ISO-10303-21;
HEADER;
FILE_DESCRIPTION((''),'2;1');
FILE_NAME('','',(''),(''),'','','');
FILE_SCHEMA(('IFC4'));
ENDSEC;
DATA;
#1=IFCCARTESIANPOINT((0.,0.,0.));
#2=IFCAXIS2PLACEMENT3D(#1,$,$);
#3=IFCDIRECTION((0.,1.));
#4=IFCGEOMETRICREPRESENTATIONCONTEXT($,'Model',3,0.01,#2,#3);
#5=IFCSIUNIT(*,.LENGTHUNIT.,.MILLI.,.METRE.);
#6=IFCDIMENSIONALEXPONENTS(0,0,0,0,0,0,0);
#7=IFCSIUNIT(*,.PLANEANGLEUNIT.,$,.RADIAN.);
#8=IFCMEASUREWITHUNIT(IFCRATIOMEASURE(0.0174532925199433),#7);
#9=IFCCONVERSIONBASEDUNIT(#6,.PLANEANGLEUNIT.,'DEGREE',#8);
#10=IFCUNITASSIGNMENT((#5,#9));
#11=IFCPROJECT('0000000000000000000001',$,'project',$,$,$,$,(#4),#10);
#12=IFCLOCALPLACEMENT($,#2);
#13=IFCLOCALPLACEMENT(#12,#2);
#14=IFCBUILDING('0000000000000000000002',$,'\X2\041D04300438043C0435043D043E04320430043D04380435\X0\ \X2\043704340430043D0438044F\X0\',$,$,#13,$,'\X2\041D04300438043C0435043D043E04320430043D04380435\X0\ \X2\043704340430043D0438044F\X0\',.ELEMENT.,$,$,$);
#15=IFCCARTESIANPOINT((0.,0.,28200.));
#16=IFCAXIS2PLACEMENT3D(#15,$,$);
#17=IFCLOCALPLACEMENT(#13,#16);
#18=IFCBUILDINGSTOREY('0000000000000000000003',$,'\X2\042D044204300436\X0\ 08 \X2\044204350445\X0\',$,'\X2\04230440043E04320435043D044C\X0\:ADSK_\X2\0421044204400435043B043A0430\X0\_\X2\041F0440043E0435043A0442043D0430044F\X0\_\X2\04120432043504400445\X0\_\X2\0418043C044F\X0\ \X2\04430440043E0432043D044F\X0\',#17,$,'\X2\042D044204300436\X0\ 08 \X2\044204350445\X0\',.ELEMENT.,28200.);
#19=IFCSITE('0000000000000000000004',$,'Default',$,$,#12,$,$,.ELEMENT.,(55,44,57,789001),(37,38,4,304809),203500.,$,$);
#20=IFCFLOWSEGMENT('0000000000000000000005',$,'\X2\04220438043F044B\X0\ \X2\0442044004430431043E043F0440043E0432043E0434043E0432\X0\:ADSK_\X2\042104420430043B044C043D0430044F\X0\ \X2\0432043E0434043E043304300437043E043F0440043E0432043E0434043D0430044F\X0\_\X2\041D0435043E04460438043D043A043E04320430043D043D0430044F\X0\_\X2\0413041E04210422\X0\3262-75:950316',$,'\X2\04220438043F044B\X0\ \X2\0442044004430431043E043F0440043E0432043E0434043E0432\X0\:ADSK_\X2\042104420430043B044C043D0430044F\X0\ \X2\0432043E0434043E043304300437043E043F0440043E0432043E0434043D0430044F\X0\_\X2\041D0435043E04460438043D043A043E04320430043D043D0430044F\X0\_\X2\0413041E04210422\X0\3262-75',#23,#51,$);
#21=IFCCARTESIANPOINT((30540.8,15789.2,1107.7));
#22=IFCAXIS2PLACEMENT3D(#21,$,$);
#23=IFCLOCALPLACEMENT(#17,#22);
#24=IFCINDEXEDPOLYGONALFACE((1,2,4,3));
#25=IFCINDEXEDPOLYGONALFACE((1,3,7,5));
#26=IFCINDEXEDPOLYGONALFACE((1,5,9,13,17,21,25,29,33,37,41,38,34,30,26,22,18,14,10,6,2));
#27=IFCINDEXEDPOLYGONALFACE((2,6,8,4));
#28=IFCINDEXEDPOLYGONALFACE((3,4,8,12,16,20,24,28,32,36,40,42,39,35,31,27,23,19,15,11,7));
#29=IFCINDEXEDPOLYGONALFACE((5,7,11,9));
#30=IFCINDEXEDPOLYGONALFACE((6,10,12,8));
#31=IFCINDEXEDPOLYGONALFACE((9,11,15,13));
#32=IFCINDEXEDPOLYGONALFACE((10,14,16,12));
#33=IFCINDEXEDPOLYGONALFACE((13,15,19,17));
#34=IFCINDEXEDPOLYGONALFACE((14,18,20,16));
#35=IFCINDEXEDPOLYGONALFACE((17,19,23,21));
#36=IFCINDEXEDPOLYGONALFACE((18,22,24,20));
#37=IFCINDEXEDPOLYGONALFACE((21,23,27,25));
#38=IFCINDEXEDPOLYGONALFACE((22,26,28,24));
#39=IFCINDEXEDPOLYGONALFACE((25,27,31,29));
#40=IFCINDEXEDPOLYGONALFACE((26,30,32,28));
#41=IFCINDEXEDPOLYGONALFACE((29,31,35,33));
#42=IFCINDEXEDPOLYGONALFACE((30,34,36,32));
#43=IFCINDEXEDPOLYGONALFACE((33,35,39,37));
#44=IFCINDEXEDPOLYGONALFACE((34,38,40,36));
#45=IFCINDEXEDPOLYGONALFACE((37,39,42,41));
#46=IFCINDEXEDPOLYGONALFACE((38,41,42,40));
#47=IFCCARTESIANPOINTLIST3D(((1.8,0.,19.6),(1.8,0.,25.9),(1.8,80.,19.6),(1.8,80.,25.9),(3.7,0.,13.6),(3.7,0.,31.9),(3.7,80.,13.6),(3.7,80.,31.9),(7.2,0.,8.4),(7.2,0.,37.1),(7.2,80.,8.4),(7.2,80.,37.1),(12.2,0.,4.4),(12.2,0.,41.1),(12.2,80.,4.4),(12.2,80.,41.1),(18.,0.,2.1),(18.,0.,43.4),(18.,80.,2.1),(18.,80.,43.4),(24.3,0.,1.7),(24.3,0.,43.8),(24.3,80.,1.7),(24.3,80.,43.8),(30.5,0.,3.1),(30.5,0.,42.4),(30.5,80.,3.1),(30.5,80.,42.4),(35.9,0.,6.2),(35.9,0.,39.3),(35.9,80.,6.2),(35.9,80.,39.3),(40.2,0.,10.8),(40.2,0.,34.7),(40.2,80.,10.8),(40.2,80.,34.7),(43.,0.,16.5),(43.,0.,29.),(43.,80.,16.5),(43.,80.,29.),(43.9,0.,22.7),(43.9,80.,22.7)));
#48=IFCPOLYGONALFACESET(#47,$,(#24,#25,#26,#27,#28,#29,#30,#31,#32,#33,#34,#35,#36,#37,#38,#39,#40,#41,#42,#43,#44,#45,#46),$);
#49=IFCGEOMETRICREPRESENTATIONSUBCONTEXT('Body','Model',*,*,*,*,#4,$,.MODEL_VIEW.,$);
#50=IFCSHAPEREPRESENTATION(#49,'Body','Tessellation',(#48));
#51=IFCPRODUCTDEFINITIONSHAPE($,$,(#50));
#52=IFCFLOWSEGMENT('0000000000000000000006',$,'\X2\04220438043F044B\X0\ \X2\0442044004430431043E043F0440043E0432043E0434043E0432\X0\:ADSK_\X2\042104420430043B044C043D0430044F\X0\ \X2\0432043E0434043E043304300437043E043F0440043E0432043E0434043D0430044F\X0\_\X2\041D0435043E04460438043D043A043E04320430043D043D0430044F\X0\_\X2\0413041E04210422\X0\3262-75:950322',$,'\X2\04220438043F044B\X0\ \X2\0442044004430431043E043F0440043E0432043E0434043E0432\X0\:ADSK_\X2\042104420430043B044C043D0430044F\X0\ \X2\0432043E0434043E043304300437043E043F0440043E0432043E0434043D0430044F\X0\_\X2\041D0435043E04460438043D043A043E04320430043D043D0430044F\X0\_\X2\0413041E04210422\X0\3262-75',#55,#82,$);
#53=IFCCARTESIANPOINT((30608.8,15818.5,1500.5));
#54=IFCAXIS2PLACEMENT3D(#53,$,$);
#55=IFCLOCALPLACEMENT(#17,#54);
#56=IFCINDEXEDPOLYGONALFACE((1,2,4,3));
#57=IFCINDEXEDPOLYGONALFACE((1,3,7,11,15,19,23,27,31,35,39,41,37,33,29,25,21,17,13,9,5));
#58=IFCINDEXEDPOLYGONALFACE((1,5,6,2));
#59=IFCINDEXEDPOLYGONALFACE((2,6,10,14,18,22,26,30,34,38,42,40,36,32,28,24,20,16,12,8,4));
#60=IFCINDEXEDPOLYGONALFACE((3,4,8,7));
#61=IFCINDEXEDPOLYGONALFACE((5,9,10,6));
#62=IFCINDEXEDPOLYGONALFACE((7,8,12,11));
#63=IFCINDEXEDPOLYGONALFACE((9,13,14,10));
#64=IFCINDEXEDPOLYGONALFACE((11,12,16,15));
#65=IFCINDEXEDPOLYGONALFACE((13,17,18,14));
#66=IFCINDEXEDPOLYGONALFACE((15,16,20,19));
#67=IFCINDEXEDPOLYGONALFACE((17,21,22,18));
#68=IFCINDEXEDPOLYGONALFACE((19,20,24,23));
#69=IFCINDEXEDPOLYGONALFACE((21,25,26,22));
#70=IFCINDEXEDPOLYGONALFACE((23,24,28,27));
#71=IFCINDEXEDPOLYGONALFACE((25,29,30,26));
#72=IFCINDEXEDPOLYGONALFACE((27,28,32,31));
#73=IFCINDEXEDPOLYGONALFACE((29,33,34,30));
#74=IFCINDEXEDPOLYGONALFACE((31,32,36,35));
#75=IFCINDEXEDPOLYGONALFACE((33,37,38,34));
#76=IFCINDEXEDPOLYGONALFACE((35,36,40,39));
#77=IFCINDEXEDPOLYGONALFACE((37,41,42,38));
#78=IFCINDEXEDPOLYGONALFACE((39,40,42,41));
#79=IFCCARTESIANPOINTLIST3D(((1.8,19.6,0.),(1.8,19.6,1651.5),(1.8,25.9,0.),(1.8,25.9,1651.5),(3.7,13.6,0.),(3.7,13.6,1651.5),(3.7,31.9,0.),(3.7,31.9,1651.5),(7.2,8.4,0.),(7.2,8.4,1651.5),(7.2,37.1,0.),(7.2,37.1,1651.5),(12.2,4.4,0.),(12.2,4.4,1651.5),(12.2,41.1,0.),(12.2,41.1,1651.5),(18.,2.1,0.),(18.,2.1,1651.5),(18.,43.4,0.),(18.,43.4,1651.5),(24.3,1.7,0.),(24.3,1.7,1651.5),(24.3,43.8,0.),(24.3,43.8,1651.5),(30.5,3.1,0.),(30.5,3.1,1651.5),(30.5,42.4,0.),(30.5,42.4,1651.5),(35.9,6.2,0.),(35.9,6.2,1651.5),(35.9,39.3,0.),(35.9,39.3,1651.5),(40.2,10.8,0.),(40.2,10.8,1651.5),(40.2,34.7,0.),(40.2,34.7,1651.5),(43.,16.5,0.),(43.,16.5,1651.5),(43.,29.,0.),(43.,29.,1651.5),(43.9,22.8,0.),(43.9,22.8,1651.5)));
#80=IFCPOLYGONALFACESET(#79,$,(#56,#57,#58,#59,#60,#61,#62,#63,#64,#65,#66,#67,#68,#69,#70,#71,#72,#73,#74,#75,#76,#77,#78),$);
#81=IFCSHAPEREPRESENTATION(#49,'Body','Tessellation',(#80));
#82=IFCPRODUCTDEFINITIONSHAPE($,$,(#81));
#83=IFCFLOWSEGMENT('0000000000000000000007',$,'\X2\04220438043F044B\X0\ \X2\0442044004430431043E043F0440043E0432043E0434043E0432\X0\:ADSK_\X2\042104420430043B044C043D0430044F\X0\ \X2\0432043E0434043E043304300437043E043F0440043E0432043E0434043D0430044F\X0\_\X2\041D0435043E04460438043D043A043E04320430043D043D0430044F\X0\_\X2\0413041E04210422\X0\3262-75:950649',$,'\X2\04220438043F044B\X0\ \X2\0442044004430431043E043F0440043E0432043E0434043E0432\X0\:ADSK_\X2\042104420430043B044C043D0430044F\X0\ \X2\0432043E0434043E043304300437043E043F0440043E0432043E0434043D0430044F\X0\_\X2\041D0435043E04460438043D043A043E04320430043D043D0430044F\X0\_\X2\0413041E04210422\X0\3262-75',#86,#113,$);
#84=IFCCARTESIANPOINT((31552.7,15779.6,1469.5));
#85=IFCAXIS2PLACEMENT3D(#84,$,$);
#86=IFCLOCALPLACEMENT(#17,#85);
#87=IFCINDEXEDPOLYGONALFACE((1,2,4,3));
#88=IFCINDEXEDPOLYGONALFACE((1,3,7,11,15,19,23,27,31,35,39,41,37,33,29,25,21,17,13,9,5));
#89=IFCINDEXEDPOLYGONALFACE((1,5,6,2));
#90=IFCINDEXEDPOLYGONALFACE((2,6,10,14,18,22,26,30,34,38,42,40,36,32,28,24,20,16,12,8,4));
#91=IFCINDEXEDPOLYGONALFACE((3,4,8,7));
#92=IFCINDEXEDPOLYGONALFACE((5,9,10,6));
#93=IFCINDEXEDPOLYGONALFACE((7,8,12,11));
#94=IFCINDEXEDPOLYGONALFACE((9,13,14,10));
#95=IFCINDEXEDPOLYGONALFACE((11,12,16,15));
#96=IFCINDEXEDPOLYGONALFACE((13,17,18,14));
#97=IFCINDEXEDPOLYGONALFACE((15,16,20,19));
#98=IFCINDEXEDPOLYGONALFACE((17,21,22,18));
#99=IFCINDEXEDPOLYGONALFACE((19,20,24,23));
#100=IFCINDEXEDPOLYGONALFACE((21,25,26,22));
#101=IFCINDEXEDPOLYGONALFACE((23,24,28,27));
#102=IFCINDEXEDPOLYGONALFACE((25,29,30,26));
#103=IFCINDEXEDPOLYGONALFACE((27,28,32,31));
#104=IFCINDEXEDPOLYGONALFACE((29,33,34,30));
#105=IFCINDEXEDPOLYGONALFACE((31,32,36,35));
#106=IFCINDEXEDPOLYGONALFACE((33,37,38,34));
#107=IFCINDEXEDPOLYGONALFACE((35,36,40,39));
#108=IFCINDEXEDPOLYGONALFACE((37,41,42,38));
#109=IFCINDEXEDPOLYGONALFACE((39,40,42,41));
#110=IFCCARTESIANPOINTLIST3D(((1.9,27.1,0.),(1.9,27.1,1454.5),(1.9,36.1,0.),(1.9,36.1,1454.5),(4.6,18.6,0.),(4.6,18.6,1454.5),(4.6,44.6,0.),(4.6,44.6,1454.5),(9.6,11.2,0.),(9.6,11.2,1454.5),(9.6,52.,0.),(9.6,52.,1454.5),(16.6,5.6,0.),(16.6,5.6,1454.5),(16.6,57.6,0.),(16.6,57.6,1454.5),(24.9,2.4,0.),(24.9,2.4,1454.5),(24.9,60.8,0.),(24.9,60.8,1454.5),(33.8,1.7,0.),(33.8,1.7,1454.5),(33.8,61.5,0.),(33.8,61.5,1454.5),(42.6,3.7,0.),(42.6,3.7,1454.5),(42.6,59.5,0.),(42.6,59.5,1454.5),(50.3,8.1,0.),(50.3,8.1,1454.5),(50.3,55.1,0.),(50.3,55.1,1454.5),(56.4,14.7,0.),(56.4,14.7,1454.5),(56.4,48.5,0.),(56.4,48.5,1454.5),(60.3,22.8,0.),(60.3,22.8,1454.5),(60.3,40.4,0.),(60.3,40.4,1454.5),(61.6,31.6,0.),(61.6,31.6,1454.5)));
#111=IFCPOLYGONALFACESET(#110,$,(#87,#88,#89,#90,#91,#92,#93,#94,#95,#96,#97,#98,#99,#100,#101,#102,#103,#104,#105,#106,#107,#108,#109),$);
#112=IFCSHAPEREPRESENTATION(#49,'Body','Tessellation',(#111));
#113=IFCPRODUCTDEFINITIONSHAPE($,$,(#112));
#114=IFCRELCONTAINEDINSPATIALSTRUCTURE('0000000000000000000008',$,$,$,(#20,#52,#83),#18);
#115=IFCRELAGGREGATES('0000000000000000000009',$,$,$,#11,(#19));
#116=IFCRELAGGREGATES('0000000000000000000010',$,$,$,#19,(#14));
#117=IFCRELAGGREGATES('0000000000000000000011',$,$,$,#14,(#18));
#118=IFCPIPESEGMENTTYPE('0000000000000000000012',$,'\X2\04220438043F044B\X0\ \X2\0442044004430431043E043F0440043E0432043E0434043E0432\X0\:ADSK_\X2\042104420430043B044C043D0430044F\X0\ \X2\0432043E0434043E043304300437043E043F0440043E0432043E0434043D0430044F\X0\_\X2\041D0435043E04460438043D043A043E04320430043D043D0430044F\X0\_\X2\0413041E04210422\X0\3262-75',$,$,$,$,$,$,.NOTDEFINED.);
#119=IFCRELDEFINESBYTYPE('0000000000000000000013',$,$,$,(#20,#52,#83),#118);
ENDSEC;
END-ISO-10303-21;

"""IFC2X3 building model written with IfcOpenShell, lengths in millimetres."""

from ifc_helpers import new_model, entity, si_unit, converted_unit, direction, frame, origin, origin_2d_with_axis, place, context, subcontext, project, spatial, circle, extrude, type_object, element, save


model = new_model("IFC2X3")

# Units and contexts
model_context = context("Model", 3, precision=0.01, world=origin(), true_north=direction((0.0, 1.0)))
body_context = subcontext(model_context, "Body", "Model", "MODEL_VIEW")
ifc_project = project(units=[si_unit("LENGTHUNIT", "METRE", prefix="MILLI"), converted_unit("PLANEANGLEUNIT", "DEGREE", entity("IfcRatioMeasure", 0.0174532925199433), si_unit("PLANEANGLEUNIT", "RADIAN"), dimensions=[0, 0, 0, 0, 0, 0, 0])], contexts=[model_context])

# Site, building, storey
site_placement = place(None, origin())
site = spatial("IfcSite", under=ifc_project, at=site_placement, Name="Default", CompositionType="ELEMENT", RefLatitude=(55, 44, 57, 789001), RefLongitude=(37, 38, 4, 304809), RefElevation=203500.0)
building_placement = place(site_placement, origin())
building = spatial("IfcBuilding", under=site, at=building_placement, Name="Наименование здания", LongName="Наименование здания", CompositionType="ELEMENT")
storey_placement = place(building_placement, frame((0.0, 0.0, 28200.0)))
storey = spatial("IfcBuildingStorey", under=building, at=storey_placement, Name="Этаж 08 тех", ObjectType="Уровень:ADSK_Стрелка_Проектная_Вверх_Имя уровня", LongName="Этаж 08 тех", CompositionType="ELEMENT", Elevation=28200.0)

# Flow segments
pipe_segment_type = type_object("IfcPipeSegmentType", Name="Типы трубопроводов:ADSK_Стальная водогазопроводная_Неоцинкованная_ГОСТ3262-75", PredefinedType="NOTDEFINED")
flow_segment_1_placement = place(storey_placement, frame((30540.8, 15789.2, 1107.7)))
element("IfcFlowSegment", 1, at=flow_segment_1_placement, inside=storey, type_object=pipe_segment_type, Name="Типы трубопроводов:ADSK_Стальная водогазопроводная_Неоцинкованная_ГОСТ3262-75:950316", ObjectType="Типы трубопроводов:ADSK_Стальная водогазопроводная_Неоцинкованная_ГОСТ3262-75", context=body_context, shape_type="SweptSolid", body=[
    extrude(circle(Radius=21.1, at=origin_2d_with_axis()), frame((22.8, 0.0, 22.8), z_axis=(0.0, 1.0, 0.0), x_axis=(1.0, 0.0, 0.0)), (0.0, 0.0, 1.0), 80.0),
])
flow_segment_2_placement = place(storey_placement, frame((30608.8, 15818.5, 1500.5)))
element("IfcFlowSegment", 2, at=flow_segment_2_placement, inside=storey, type_object=pipe_segment_type, Name="Типы трубопроводов:ADSK_Стальная водогазопроводная_Неоцинкованная_ГОСТ3262-75:950322", ObjectType="Типы трубопроводов:ADSK_Стальная водогазопроводная_Неоцинкованная_ГОСТ3262-75", context=body_context, shape_type="SweptSolid", body=[
    extrude(circle(Radius=21.1, at=origin_2d_with_axis()), frame((22.8, 22.8, 0.0)), (0.0, 0.0, 1.0), 1651.5),
])
flow_segment_3_placement = place(storey_placement, frame((31552.7, 15779.6, 1469.5)))
element("IfcFlowSegment", 3, at=flow_segment_3_placement, inside=storey, type_object=pipe_segment_type, Name="Типы трубопроводов:ADSK_Стальная водогазопроводная_Неоцинкованная_ГОСТ3262-75:950649", ObjectType="Типы трубопроводов:ADSK_Стальная водогазопроводная_Неоцинкованная_ГОСТ3262-75", context=body_context, shape_type="SweptSolid", body=[
    extrude(circle(Radius=30.0, at=origin_2d_with_axis()), frame((31.6, 31.6, 0.0)), (0.0, 0.0, 1.0), 1454.5),
])

save(model, "model.ifc")
